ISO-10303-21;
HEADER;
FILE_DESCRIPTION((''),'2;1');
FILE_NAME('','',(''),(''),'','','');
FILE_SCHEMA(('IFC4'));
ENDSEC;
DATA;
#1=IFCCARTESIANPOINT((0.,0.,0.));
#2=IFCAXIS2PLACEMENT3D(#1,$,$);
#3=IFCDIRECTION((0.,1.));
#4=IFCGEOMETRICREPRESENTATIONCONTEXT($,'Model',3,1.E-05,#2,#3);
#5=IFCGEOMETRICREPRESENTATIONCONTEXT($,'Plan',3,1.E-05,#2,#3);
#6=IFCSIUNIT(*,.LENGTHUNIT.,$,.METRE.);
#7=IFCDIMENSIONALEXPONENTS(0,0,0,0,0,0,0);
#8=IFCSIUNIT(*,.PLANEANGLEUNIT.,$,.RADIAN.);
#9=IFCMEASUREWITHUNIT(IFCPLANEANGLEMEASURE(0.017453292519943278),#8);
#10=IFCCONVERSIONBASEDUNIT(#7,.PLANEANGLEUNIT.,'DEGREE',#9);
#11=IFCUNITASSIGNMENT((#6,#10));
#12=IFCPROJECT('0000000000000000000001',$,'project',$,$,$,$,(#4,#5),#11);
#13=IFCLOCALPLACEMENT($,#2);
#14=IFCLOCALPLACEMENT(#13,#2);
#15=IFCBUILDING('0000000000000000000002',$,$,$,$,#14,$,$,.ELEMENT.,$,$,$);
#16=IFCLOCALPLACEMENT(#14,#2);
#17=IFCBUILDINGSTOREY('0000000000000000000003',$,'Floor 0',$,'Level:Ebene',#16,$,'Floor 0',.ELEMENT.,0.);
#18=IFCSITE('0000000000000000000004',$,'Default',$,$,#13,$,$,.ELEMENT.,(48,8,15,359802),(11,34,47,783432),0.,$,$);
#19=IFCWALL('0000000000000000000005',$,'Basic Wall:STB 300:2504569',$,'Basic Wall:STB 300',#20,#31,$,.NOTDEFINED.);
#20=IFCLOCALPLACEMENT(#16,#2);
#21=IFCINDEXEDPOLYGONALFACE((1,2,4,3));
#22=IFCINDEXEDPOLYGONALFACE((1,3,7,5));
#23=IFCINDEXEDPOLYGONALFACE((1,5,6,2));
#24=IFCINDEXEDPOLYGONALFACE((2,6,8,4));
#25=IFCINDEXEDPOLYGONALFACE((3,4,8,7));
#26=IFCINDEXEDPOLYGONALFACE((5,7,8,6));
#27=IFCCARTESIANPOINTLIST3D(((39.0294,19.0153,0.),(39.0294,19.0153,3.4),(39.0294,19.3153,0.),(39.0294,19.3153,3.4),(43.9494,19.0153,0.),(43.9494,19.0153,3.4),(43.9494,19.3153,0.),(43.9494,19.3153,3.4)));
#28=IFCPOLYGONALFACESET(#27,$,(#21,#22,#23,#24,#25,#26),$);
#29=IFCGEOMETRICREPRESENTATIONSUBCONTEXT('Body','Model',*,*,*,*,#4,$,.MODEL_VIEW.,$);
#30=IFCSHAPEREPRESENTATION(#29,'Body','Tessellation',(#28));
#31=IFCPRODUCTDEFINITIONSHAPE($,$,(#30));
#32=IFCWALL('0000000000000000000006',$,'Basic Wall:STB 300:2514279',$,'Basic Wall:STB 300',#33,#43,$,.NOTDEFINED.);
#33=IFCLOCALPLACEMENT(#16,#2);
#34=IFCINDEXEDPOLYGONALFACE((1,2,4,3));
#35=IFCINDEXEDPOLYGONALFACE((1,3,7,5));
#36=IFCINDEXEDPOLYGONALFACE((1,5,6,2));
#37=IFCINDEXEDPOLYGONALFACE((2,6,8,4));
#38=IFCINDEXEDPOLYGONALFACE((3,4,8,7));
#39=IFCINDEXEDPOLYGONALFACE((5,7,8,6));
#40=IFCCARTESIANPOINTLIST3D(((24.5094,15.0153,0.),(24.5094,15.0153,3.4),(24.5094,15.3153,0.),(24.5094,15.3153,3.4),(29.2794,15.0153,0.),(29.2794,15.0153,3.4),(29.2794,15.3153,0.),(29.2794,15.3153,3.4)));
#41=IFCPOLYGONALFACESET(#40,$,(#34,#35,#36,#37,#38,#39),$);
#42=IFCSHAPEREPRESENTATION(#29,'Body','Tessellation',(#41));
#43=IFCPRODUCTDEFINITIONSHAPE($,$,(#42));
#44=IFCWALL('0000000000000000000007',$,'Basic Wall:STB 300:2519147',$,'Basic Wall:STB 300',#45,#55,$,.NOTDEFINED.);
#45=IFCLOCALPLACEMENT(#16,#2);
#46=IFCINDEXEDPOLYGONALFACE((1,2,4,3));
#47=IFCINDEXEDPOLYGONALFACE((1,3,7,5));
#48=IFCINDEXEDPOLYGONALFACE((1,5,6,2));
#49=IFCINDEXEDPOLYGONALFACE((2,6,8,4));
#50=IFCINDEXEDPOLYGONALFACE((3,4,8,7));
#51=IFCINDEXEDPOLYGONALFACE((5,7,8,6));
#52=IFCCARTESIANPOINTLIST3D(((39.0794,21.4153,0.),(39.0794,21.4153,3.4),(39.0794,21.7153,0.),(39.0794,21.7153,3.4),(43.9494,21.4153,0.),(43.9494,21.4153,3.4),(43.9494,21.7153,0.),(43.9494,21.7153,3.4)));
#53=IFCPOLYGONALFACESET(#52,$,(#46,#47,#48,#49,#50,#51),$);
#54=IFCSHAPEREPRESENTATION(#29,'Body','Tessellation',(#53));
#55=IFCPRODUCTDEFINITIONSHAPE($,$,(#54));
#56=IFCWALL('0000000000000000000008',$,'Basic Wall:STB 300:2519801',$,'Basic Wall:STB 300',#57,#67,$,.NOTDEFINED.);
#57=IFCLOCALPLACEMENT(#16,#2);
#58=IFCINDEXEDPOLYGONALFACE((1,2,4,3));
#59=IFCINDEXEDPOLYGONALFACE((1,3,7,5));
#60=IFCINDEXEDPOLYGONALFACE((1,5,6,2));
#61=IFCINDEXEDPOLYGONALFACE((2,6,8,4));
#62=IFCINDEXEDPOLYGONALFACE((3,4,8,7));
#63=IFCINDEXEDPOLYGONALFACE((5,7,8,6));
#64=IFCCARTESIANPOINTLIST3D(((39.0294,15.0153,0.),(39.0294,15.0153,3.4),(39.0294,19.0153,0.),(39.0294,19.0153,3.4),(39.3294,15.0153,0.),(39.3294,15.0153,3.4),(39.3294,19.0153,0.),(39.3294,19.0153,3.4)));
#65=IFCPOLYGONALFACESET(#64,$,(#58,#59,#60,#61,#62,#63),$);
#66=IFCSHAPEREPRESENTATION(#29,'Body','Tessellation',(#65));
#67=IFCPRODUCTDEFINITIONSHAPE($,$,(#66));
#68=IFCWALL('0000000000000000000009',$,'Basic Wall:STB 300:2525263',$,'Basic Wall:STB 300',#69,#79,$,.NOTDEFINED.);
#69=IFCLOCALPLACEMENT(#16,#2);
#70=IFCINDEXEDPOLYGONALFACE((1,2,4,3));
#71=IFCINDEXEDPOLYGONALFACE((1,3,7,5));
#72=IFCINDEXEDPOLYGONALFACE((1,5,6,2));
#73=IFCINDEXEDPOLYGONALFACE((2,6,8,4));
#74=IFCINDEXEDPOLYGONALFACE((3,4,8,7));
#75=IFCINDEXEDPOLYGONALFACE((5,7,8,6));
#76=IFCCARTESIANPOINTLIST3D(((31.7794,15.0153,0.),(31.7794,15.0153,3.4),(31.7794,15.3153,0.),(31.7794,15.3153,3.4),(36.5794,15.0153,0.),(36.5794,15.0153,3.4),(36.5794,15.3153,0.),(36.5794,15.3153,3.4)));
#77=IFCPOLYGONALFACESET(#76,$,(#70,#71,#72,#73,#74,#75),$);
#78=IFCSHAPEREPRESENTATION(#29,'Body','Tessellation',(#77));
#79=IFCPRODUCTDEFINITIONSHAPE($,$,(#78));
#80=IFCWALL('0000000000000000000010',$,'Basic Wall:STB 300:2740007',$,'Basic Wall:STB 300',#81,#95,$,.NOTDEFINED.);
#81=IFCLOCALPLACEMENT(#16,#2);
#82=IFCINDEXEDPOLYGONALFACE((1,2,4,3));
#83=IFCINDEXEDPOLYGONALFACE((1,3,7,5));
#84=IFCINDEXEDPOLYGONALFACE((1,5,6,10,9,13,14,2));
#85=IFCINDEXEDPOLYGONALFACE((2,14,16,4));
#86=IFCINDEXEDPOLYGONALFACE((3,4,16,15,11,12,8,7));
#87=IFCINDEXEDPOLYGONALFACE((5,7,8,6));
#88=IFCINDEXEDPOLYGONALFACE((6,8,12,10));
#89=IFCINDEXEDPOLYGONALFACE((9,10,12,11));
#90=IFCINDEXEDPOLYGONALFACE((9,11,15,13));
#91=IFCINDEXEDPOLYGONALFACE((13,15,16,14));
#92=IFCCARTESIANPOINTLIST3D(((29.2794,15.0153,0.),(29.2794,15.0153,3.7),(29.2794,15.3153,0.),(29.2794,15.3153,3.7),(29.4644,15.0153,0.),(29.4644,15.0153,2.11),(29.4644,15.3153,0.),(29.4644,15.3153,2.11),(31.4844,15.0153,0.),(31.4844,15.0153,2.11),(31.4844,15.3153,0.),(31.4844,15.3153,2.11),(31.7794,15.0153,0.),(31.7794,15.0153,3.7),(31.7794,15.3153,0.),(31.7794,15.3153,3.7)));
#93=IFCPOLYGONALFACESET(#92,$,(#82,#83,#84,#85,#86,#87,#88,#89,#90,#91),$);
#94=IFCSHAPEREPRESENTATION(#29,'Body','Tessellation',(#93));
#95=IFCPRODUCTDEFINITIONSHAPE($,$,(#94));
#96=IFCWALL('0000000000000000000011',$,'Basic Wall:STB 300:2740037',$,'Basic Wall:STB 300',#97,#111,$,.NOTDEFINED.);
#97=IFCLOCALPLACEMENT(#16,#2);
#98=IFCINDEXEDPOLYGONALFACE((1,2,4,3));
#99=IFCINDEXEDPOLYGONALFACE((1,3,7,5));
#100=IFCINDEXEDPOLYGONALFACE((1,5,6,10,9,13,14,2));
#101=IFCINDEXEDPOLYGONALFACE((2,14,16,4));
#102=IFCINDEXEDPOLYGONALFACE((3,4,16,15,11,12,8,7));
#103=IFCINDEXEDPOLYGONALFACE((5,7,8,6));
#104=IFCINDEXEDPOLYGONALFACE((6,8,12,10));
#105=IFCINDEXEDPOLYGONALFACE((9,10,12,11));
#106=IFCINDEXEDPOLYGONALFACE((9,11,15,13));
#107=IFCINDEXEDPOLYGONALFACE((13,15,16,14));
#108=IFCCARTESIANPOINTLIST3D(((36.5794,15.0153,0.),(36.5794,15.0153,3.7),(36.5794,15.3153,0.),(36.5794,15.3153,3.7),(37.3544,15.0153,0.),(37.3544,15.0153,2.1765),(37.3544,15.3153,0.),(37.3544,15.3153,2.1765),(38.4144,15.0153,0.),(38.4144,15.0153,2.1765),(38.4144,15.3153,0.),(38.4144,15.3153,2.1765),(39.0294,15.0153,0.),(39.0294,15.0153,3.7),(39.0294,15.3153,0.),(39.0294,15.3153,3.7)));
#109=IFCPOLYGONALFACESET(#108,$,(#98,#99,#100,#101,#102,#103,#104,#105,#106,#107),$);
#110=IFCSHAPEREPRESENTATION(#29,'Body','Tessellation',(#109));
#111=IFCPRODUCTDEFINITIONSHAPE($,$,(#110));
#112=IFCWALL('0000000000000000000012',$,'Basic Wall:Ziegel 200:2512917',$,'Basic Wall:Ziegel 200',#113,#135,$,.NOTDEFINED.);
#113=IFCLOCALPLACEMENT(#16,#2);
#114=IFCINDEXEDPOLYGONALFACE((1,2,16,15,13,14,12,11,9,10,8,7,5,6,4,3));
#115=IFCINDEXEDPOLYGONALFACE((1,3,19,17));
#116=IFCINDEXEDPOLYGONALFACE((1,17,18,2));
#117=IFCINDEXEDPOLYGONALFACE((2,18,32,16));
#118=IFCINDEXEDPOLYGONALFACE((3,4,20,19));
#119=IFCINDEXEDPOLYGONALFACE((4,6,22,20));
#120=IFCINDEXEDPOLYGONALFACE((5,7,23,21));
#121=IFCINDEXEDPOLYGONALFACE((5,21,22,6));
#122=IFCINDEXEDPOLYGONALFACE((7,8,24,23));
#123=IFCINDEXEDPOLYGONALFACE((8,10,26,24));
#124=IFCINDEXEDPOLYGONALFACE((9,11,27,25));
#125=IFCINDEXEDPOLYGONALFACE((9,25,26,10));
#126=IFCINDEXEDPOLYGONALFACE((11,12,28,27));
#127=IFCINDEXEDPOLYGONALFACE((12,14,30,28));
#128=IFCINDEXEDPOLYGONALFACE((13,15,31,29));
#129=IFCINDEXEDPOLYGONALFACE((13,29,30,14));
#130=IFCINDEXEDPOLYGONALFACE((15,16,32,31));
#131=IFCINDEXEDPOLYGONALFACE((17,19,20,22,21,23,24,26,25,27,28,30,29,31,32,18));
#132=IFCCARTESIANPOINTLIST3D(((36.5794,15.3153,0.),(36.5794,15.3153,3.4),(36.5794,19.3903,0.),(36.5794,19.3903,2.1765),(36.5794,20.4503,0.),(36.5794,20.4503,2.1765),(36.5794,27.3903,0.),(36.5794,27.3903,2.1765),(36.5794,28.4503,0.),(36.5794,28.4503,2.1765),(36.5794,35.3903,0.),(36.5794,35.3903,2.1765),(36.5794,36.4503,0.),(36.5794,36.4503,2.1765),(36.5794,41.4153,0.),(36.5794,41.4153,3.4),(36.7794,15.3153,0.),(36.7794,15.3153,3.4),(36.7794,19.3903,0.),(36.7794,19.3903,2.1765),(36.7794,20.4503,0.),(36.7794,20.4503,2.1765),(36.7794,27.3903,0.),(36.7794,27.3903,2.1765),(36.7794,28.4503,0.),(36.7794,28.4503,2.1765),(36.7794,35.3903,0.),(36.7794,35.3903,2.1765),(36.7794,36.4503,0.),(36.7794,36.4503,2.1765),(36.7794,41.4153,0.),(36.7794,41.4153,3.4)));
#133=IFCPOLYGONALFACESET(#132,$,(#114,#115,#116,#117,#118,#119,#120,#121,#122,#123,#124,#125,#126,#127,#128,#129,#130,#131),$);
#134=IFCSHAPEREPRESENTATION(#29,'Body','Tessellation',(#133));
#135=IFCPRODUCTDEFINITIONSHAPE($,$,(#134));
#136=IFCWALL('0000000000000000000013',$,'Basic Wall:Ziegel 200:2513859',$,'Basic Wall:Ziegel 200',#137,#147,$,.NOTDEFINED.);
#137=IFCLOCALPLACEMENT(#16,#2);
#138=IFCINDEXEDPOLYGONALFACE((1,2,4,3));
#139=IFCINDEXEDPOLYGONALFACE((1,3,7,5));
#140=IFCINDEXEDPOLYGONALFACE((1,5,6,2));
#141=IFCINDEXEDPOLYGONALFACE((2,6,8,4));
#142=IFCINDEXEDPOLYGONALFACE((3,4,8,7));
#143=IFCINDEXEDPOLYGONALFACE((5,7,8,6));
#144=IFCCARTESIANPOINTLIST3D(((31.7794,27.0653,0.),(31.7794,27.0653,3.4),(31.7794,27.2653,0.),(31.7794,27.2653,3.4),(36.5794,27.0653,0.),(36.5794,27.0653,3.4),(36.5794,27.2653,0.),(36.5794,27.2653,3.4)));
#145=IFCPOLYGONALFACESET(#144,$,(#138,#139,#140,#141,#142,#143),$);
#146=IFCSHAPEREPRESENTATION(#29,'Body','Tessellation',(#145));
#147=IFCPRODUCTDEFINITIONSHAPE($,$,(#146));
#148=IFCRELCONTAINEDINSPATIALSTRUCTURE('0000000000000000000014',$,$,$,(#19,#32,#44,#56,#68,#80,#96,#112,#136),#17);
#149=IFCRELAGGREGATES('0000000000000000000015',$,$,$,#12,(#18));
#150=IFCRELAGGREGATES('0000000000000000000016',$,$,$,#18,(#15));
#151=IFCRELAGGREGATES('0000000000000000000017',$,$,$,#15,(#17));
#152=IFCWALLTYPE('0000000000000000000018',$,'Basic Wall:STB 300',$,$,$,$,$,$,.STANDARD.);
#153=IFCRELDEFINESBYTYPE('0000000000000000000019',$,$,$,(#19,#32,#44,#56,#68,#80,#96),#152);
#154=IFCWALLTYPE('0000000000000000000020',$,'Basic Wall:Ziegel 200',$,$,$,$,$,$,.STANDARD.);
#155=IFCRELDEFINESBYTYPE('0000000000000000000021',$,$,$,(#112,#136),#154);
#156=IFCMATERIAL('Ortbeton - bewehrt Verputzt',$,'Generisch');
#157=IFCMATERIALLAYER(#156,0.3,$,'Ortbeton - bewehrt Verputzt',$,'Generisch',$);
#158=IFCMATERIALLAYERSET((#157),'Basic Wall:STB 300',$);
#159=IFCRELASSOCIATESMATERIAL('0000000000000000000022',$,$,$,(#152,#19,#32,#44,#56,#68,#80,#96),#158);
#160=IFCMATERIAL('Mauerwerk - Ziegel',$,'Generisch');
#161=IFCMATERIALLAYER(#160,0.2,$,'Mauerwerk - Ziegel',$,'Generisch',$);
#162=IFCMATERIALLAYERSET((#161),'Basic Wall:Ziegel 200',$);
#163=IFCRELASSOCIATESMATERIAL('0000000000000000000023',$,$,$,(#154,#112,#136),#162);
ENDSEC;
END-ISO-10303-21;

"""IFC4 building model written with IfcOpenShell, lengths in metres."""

from ifc_helpers import new_model, entity, si_unit, converted_unit, direction, frame, frame_2d, origin, place, context, subcontext, project, spatial, polyline, rectangle, extrude, clip, bounded_halfspace, material, layer, layer_set, layer_usage, type_object, element, save


model = new_model("IFC4")

# Units and contexts
model_context = context("Model", 3, precision=1e-05, world=origin(), true_north=direction((0.0, 1.0)))
plan_context = context("Plan", 3, precision=1e-05, world=origin(), true_north=direction((0.0, 1.0)))
body_context = subcontext(model_context, "Body", "Model", "MODEL_VIEW")
ifc_project = project(units=[si_unit("LENGTHUNIT", "METRE"), converted_unit("PLANEANGLEUNIT", "DEGREE", entity("IfcPlaneAngleMeasure", 0.017453292519943278), si_unit("PLANEANGLEUNIT", "RADIAN"), dimensions=[0, 0, 0, 0, 0, 0, 0])], contexts=[model_context, plan_context])

# Site, building, storey
site_placement = place(None, origin())
site = spatial("IfcSite", under=ifc_project, at=site_placement, Name="Default", CompositionType="ELEMENT", RefLatitude=(48, 8, 15, 359802), RefLongitude=(11, 34, 47, 783432), RefElevation=0.0)
building_placement = place(site_placement, origin())
building = spatial("IfcBuilding", under=site, at=building_placement, CompositionType="ELEMENT")
storey_placement = place(building_placement, origin())
storey = spatial("IfcBuildingStorey", under=building, at=storey_placement, Name="Floor 0", ObjectType="Level:Ebene", LongName="Floor 0", CompositionType="ELEMENT", Elevation=0.0)

# Walls
ifc_material_1 = material(Name="Ortbeton - bewehrt Verputzt", Category="Generisch")
ifc_layer_1 = layer(ifc_material_1, 0.3, Name="Ortbeton - bewehrt Verputzt", Category="Generisch")
ifc_layer_set_1 = layer_set([ifc_layer_1], Name="Basic Wall:STB 300")
ifc_layer_usage_1 = layer_usage(ifc_layer_set_1, "AXIS2", "NEGATIVE", 0.15)
wall_type_1 = type_object("IfcWallType", Name="Basic Wall:STB 300", PredefinedType="STANDARD", material=ifc_layer_set_1)
wall_1_placement = place(storey_placement, frame((43.9494, 19.1653, 0.0), z_axis=(0.0, 0.0, 1.0), x_axis=(-1.0, 0.0, 0.0)))
element("IfcWall", 1, at=wall_1_placement, inside=storey, type_object=wall_type_1, material=ifc_layer_usage_1, Name="Basic Wall:STB 300:2504569", ObjectType="Basic Wall:STB 300", PredefinedType="NOTDEFINED", context=body_context, shape_type="Clipping", body=[
    clip(extrude(rectangle(XDim=4.92, YDim=0.3, at=frame_2d((2.46, 0.0), x_axis=(-1.0, 0.0))), origin(), (0.0, 0.0, 1.0), 3.4), bounded_halfspace(frame((0.0, -0.15, 3.4), z_axis=(0.0, 0.0, -1.0), x_axis=(1.0, 0.0, 0.0)), True, frame((0.0, -0.15, 3.4)), polyline([(0.0, 0.0), (4.92, 0.0), (4.92, 0.3), (0.0, 0.3), (0.0, 0.0)]))),
])
wall_2_placement = place(storey_placement, frame((24.5094, 15.1653, 0.0)))
element("IfcWall", 2, at=wall_2_placement, inside=storey, type_object=wall_type_1, material=ifc_layer_usage_1, Name="Basic Wall:STB 300:2514279", ObjectType="Basic Wall:STB 300", PredefinedType="NOTDEFINED", context=body_context, shape_type="Clipping", body=[
    clip(extrude(rectangle(XDim=4.77, YDim=0.3, at=frame_2d((2.385, 0.0), x_axis=(-1.0, 0.0))), origin(), (0.0, 0.0, 1.0), 3.4), bounded_halfspace(frame((0.0, -0.15, 3.4), z_axis=(0.0, 0.0, -1.0), x_axis=(-1.0, 0.0, 0.0)), True, frame((0.0, -0.15, 3.4)), polyline([(0.0, 0.0), (4.77, 0.0), (4.77, 0.3), (4.67, 0.3), (0.0, 0.3), (0.0, 0.0)]))),
])
wall_3_placement = place(storey_placement, frame((39.0794, 21.5653, 0.0)))
element("IfcWall", 3, at=wall_3_placement, inside=storey, type_object=wall_type_1, material=ifc_layer_usage_1, Name="Basic Wall:STB 300:2519147", ObjectType="Basic Wall:STB 300", PredefinedType="NOTDEFINED", context=body_context, shape_type="Clipping", body=[
    clip(extrude(rectangle(XDim=4.87, YDim=0.3, at=frame_2d((2.435, 0.0), x_axis=(-1.0, 0.0))), origin(), (0.0, 0.0, 1.0), 3.4), bounded_halfspace(frame((0.0, -0.15, 3.4), z_axis=(0.0, 0.0, -1.0), x_axis=(-1.0, 0.0, 0.0)), True, frame((0.0, -0.15, 3.4)), polyline([(0.0, 0.0), (1.87, 0.0), (4.87, 0.0), (4.87, 0.3), (0.0, 0.3), (0.0, 0.0)]))),
])
wall_4_placement = place(storey_placement, frame((39.1794, 19.0153, 0.0), z_axis=(0.0, 0.0, 1.0), x_axis=(0.0, -1.0, 0.0)))
element("IfcWall", 4, at=wall_4_placement, inside=storey, type_object=wall_type_1, material=ifc_layer_usage_1, Name="Basic Wall:STB 300:2519801", ObjectType="Basic Wall:STB 300", PredefinedType="NOTDEFINED", context=body_context, shape_type="Clipping", body=[
    clip(extrude(rectangle(XDim=4.0, YDim=0.3, at=frame_2d((2.0, 0.0), x_axis=(-1.0, 0.0))), origin(), (0.0, 0.0, 1.0), 3.4), bounded_halfspace(frame((0.0, -0.15, 3.4), z_axis=(0.0, 0.0, -1.0), x_axis=(0.0, -1.0, 0.0)), True, frame((0.0, -0.15, 3.4)), polyline([(0.0, 0.0), (4.0, 0.0), (4.0, 0.3), (3.8, 0.3), (0.0, 0.3), (0.0, 0.0)]))),
])
wall_5_placement = place(storey_placement, frame((31.7794, 15.1653, 0.0)))
element("IfcWall", 5, at=wall_5_placement, inside=storey, type_object=wall_type_1, material=ifc_layer_usage_1, Name="Basic Wall:STB 300:2525263", ObjectType="Basic Wall:STB 300", PredefinedType="NOTDEFINED", context=body_context, shape_type="Clipping", body=[
    clip(extrude(rectangle(XDim=4.8, YDim=0.3, at=frame_2d((2.4, 0.0), x_axis=(-1.0, 0.0))), origin(), (0.0, 0.0, 1.0), 3.4), bounded_halfspace(frame((0.0, -0.15, 3.4), z_axis=(0.0, 0.0, -1.0), x_axis=(-1.0, 0.0, 0.0)), True, frame((0.0, -0.15, 3.4)), polyline([(0.0, 0.0), (4.8, 0.0), (4.8, 0.3), (0.0, 0.3), (0.0, 0.0)]))),
])

# Walls, openings
wall_6_placement = place(storey_placement, frame((29.2794, 15.1653, 0.0)))
wall_6 = element("IfcWall", 6, at=wall_6_placement, inside=storey, type_object=wall_type_1, material=ifc_layer_usage_1, Name="Basic Wall:STB 300:2740007", ObjectType="Basic Wall:STB 300", PredefinedType="NOTDEFINED", context=body_context, shape_type="SweptSolid", body=[
    extrude(rectangle(XDim=2.5, YDim=0.3, at=frame_2d((1.25, 0.0), x_axis=(-1.0, 0.0))), origin(), (0.0, 0.0, 1.0), 3.7),
])
opening_1_placement = place(wall_6_placement, frame((0.185, -0.15, 0.0)))
element("IfcOpeningElement", 7, at=opening_1_placement, cuts=wall_6, PredefinedType="OPENING", context=body_context, shape_type="SweptSolid", body=[
    extrude(rectangle(XDim=2.11, YDim=2.02, at=frame_2d((1.055, 1.01), x_axis=(1.0, 0.0))), frame((0.0, 0.0, 0.0), z_axis=(0.0, 1.0, 0.0), x_axis=(0.0, 0.0, 1.0)), (0.0, 0.0, 1.0), 0.3),
])
wall_7_placement = place(storey_placement, frame((36.5794, 15.1653, 0.0)))
wall_7 = element("IfcWall", 8, at=wall_7_placement, inside=storey, type_object=wall_type_1, material=ifc_layer_usage_1, Name="Basic Wall:STB 300:2740037", ObjectType="Basic Wall:STB 300", PredefinedType="NOTDEFINED", context=body_context, shape_type="SweptSolid", body=[
    extrude(rectangle(XDim=2.45, YDim=0.3, at=frame_2d((1.225, 0.0), x_axis=(-1.0, 0.0))), origin(), (0.0, 0.0, 1.0), 3.7),
])
opening_2_placement = place(wall_7_placement, frame((1.835, 0.15, 0.0)))
element("IfcOpeningElement", 9, at=opening_2_placement, cuts=wall_7, PredefinedType="OPENING", context=body_context, shape_type="SweptSolid", body=[
    extrude(rectangle(XDim=2.1765, YDim=1.06, at=frame_2d((1.0882, 0.53), x_axis=(1.0, 0.0))), frame((0.0, 0.0, 0.0), z_axis=(0.0, -1.0, 0.0), x_axis=(0.0, 0.0, 1.0)), (0.0, 0.0, 1.0), 0.3),
])

# Wall, openings
ifc_material_2 = material(Name="Mauerwerk - Ziegel", Category="Generisch")
ifc_layer_2 = layer(ifc_material_2, 0.2, Name="Mauerwerk - Ziegel", Category="Generisch")
ifc_layer_set_2 = layer_set([ifc_layer_2], Name="Basic Wall:Ziegel 200")
ifc_layer_usage_2 = layer_usage(ifc_layer_set_2, "AXIS2", "NEGATIVE", 0.1)
wall_type_2 = type_object("IfcWallType", Name="Basic Wall:Ziegel 200", PredefinedType="STANDARD", material=ifc_layer_set_2)
wall_8_placement = place(storey_placement, frame((36.6794, 15.3153, 0.0), z_axis=(0.0, 0.0, 1.0), x_axis=(0.0, 1.0, 0.0)))
wall_8 = element("IfcWall", 10, at=wall_8_placement, inside=storey, type_object=wall_type_2, material=ifc_layer_usage_2, Name="Basic Wall:Ziegel 200:2512917", ObjectType="Basic Wall:Ziegel 200", PredefinedType="NOTDEFINED", context=body_context, shape_type="Clipping", body=[
    clip(extrude(rectangle(XDim=26.1, YDim=0.2, at=frame_2d((13.05, 0.0), x_axis=(-1.0, 0.0))), origin(), (0.0, 0.0, 1.0), 3.4), bounded_halfspace(frame((0.0, -0.1, 3.4), z_axis=(0.0, 0.0, -1.0), x_axis=(0.0, 1.0, 0.0)), True, frame((0.0, -0.1, 3.4)), polyline([(0.0, 0.0), (26.1, 0.0), (26.1, 0.2), (19.95, 0.2), (19.75, 0.2), (11.95, 0.2), (11.75, 0.2), (3.95, 0.2), (3.75, 0.2), (0.0, 0.2), (0.0, 0.0)]))),
])
opening_3_placement = place(wall_8_placement, frame((21.135, 0.1, 0.0)))
element("IfcOpeningElement", 11, at=opening_3_placement, cuts=wall_8, PredefinedType="OPENING", context=body_context, shape_type="SweptSolid", body=[
    extrude(rectangle(XDim=2.1765, YDim=1.06, at=frame_2d((1.0882, 0.53), x_axis=(1.0, 0.0))), frame((0.0, 0.0, 0.0), z_axis=(0.0, -1.0, 0.0), x_axis=(0.0, 0.0, 1.0)), (0.0, 0.0, 1.0), 0.2),
])
opening_4_placement = place(wall_8_placement, frame((13.135, 0.1, 0.0)))
element("IfcOpeningElement", 12, at=opening_4_placement, cuts=wall_8, PredefinedType="OPENING", context=body_context, shape_type="SweptSolid", body=[
    extrude(rectangle(XDim=2.1765, YDim=1.06, at=frame_2d((1.0882, 0.53), x_axis=(1.0, 0.0))), frame((0.0, 0.0, 0.0), z_axis=(0.0, -1.0, 0.0), x_axis=(0.0, 0.0, 1.0)), (0.0, 0.0, 1.0), 0.2),
])
opening_5_placement = place(wall_8_placement, frame((5.135, 0.1, 0.0)))
element("IfcOpeningElement", 13, at=opening_5_placement, cuts=wall_8, PredefinedType="OPENING", context=body_context, shape_type="SweptSolid", body=[
    extrude(rectangle(XDim=2.1765, YDim=1.06, at=frame_2d((1.0882, 0.53), x_axis=(1.0, 0.0))), frame((0.0, 0.0, 0.0), z_axis=(0.0, -1.0, 0.0), x_axis=(0.0, 0.0, 1.0)), (0.0, 0.0, 1.0), 0.2),
])

# Wall
wall_9_placement = place(storey_placement, frame((31.7794, 27.1653, 0.0)))
element("IfcWall", 14, at=wall_9_placement, inside=storey, type_object=wall_type_2, material=ifc_layer_usage_2, Name="Basic Wall:Ziegel 200:2513859", ObjectType="Basic Wall:Ziegel 200", PredefinedType="NOTDEFINED", context=body_context, shape_type="Clipping", body=[
    clip(extrude(rectangle(XDim=4.8, YDim=0.2, at=frame_2d((2.4, 0.0), x_axis=(-1.0, 0.0))), origin(), (0.0, 0.0, 1.0), 3.4), bounded_halfspace(frame((0.0, -0.1, 3.4), z_axis=(0.0, 0.0, -1.0), x_axis=(-1.0, 0.0, 0.0)), True, frame((0.0, -0.1, 3.4)), polyline([(0.0, 0.0), (4.8, 0.0), (4.8, 0.2), (0.0, 0.2), (0.0, 0.0)]))),
])

save(model, "model.ifc")
